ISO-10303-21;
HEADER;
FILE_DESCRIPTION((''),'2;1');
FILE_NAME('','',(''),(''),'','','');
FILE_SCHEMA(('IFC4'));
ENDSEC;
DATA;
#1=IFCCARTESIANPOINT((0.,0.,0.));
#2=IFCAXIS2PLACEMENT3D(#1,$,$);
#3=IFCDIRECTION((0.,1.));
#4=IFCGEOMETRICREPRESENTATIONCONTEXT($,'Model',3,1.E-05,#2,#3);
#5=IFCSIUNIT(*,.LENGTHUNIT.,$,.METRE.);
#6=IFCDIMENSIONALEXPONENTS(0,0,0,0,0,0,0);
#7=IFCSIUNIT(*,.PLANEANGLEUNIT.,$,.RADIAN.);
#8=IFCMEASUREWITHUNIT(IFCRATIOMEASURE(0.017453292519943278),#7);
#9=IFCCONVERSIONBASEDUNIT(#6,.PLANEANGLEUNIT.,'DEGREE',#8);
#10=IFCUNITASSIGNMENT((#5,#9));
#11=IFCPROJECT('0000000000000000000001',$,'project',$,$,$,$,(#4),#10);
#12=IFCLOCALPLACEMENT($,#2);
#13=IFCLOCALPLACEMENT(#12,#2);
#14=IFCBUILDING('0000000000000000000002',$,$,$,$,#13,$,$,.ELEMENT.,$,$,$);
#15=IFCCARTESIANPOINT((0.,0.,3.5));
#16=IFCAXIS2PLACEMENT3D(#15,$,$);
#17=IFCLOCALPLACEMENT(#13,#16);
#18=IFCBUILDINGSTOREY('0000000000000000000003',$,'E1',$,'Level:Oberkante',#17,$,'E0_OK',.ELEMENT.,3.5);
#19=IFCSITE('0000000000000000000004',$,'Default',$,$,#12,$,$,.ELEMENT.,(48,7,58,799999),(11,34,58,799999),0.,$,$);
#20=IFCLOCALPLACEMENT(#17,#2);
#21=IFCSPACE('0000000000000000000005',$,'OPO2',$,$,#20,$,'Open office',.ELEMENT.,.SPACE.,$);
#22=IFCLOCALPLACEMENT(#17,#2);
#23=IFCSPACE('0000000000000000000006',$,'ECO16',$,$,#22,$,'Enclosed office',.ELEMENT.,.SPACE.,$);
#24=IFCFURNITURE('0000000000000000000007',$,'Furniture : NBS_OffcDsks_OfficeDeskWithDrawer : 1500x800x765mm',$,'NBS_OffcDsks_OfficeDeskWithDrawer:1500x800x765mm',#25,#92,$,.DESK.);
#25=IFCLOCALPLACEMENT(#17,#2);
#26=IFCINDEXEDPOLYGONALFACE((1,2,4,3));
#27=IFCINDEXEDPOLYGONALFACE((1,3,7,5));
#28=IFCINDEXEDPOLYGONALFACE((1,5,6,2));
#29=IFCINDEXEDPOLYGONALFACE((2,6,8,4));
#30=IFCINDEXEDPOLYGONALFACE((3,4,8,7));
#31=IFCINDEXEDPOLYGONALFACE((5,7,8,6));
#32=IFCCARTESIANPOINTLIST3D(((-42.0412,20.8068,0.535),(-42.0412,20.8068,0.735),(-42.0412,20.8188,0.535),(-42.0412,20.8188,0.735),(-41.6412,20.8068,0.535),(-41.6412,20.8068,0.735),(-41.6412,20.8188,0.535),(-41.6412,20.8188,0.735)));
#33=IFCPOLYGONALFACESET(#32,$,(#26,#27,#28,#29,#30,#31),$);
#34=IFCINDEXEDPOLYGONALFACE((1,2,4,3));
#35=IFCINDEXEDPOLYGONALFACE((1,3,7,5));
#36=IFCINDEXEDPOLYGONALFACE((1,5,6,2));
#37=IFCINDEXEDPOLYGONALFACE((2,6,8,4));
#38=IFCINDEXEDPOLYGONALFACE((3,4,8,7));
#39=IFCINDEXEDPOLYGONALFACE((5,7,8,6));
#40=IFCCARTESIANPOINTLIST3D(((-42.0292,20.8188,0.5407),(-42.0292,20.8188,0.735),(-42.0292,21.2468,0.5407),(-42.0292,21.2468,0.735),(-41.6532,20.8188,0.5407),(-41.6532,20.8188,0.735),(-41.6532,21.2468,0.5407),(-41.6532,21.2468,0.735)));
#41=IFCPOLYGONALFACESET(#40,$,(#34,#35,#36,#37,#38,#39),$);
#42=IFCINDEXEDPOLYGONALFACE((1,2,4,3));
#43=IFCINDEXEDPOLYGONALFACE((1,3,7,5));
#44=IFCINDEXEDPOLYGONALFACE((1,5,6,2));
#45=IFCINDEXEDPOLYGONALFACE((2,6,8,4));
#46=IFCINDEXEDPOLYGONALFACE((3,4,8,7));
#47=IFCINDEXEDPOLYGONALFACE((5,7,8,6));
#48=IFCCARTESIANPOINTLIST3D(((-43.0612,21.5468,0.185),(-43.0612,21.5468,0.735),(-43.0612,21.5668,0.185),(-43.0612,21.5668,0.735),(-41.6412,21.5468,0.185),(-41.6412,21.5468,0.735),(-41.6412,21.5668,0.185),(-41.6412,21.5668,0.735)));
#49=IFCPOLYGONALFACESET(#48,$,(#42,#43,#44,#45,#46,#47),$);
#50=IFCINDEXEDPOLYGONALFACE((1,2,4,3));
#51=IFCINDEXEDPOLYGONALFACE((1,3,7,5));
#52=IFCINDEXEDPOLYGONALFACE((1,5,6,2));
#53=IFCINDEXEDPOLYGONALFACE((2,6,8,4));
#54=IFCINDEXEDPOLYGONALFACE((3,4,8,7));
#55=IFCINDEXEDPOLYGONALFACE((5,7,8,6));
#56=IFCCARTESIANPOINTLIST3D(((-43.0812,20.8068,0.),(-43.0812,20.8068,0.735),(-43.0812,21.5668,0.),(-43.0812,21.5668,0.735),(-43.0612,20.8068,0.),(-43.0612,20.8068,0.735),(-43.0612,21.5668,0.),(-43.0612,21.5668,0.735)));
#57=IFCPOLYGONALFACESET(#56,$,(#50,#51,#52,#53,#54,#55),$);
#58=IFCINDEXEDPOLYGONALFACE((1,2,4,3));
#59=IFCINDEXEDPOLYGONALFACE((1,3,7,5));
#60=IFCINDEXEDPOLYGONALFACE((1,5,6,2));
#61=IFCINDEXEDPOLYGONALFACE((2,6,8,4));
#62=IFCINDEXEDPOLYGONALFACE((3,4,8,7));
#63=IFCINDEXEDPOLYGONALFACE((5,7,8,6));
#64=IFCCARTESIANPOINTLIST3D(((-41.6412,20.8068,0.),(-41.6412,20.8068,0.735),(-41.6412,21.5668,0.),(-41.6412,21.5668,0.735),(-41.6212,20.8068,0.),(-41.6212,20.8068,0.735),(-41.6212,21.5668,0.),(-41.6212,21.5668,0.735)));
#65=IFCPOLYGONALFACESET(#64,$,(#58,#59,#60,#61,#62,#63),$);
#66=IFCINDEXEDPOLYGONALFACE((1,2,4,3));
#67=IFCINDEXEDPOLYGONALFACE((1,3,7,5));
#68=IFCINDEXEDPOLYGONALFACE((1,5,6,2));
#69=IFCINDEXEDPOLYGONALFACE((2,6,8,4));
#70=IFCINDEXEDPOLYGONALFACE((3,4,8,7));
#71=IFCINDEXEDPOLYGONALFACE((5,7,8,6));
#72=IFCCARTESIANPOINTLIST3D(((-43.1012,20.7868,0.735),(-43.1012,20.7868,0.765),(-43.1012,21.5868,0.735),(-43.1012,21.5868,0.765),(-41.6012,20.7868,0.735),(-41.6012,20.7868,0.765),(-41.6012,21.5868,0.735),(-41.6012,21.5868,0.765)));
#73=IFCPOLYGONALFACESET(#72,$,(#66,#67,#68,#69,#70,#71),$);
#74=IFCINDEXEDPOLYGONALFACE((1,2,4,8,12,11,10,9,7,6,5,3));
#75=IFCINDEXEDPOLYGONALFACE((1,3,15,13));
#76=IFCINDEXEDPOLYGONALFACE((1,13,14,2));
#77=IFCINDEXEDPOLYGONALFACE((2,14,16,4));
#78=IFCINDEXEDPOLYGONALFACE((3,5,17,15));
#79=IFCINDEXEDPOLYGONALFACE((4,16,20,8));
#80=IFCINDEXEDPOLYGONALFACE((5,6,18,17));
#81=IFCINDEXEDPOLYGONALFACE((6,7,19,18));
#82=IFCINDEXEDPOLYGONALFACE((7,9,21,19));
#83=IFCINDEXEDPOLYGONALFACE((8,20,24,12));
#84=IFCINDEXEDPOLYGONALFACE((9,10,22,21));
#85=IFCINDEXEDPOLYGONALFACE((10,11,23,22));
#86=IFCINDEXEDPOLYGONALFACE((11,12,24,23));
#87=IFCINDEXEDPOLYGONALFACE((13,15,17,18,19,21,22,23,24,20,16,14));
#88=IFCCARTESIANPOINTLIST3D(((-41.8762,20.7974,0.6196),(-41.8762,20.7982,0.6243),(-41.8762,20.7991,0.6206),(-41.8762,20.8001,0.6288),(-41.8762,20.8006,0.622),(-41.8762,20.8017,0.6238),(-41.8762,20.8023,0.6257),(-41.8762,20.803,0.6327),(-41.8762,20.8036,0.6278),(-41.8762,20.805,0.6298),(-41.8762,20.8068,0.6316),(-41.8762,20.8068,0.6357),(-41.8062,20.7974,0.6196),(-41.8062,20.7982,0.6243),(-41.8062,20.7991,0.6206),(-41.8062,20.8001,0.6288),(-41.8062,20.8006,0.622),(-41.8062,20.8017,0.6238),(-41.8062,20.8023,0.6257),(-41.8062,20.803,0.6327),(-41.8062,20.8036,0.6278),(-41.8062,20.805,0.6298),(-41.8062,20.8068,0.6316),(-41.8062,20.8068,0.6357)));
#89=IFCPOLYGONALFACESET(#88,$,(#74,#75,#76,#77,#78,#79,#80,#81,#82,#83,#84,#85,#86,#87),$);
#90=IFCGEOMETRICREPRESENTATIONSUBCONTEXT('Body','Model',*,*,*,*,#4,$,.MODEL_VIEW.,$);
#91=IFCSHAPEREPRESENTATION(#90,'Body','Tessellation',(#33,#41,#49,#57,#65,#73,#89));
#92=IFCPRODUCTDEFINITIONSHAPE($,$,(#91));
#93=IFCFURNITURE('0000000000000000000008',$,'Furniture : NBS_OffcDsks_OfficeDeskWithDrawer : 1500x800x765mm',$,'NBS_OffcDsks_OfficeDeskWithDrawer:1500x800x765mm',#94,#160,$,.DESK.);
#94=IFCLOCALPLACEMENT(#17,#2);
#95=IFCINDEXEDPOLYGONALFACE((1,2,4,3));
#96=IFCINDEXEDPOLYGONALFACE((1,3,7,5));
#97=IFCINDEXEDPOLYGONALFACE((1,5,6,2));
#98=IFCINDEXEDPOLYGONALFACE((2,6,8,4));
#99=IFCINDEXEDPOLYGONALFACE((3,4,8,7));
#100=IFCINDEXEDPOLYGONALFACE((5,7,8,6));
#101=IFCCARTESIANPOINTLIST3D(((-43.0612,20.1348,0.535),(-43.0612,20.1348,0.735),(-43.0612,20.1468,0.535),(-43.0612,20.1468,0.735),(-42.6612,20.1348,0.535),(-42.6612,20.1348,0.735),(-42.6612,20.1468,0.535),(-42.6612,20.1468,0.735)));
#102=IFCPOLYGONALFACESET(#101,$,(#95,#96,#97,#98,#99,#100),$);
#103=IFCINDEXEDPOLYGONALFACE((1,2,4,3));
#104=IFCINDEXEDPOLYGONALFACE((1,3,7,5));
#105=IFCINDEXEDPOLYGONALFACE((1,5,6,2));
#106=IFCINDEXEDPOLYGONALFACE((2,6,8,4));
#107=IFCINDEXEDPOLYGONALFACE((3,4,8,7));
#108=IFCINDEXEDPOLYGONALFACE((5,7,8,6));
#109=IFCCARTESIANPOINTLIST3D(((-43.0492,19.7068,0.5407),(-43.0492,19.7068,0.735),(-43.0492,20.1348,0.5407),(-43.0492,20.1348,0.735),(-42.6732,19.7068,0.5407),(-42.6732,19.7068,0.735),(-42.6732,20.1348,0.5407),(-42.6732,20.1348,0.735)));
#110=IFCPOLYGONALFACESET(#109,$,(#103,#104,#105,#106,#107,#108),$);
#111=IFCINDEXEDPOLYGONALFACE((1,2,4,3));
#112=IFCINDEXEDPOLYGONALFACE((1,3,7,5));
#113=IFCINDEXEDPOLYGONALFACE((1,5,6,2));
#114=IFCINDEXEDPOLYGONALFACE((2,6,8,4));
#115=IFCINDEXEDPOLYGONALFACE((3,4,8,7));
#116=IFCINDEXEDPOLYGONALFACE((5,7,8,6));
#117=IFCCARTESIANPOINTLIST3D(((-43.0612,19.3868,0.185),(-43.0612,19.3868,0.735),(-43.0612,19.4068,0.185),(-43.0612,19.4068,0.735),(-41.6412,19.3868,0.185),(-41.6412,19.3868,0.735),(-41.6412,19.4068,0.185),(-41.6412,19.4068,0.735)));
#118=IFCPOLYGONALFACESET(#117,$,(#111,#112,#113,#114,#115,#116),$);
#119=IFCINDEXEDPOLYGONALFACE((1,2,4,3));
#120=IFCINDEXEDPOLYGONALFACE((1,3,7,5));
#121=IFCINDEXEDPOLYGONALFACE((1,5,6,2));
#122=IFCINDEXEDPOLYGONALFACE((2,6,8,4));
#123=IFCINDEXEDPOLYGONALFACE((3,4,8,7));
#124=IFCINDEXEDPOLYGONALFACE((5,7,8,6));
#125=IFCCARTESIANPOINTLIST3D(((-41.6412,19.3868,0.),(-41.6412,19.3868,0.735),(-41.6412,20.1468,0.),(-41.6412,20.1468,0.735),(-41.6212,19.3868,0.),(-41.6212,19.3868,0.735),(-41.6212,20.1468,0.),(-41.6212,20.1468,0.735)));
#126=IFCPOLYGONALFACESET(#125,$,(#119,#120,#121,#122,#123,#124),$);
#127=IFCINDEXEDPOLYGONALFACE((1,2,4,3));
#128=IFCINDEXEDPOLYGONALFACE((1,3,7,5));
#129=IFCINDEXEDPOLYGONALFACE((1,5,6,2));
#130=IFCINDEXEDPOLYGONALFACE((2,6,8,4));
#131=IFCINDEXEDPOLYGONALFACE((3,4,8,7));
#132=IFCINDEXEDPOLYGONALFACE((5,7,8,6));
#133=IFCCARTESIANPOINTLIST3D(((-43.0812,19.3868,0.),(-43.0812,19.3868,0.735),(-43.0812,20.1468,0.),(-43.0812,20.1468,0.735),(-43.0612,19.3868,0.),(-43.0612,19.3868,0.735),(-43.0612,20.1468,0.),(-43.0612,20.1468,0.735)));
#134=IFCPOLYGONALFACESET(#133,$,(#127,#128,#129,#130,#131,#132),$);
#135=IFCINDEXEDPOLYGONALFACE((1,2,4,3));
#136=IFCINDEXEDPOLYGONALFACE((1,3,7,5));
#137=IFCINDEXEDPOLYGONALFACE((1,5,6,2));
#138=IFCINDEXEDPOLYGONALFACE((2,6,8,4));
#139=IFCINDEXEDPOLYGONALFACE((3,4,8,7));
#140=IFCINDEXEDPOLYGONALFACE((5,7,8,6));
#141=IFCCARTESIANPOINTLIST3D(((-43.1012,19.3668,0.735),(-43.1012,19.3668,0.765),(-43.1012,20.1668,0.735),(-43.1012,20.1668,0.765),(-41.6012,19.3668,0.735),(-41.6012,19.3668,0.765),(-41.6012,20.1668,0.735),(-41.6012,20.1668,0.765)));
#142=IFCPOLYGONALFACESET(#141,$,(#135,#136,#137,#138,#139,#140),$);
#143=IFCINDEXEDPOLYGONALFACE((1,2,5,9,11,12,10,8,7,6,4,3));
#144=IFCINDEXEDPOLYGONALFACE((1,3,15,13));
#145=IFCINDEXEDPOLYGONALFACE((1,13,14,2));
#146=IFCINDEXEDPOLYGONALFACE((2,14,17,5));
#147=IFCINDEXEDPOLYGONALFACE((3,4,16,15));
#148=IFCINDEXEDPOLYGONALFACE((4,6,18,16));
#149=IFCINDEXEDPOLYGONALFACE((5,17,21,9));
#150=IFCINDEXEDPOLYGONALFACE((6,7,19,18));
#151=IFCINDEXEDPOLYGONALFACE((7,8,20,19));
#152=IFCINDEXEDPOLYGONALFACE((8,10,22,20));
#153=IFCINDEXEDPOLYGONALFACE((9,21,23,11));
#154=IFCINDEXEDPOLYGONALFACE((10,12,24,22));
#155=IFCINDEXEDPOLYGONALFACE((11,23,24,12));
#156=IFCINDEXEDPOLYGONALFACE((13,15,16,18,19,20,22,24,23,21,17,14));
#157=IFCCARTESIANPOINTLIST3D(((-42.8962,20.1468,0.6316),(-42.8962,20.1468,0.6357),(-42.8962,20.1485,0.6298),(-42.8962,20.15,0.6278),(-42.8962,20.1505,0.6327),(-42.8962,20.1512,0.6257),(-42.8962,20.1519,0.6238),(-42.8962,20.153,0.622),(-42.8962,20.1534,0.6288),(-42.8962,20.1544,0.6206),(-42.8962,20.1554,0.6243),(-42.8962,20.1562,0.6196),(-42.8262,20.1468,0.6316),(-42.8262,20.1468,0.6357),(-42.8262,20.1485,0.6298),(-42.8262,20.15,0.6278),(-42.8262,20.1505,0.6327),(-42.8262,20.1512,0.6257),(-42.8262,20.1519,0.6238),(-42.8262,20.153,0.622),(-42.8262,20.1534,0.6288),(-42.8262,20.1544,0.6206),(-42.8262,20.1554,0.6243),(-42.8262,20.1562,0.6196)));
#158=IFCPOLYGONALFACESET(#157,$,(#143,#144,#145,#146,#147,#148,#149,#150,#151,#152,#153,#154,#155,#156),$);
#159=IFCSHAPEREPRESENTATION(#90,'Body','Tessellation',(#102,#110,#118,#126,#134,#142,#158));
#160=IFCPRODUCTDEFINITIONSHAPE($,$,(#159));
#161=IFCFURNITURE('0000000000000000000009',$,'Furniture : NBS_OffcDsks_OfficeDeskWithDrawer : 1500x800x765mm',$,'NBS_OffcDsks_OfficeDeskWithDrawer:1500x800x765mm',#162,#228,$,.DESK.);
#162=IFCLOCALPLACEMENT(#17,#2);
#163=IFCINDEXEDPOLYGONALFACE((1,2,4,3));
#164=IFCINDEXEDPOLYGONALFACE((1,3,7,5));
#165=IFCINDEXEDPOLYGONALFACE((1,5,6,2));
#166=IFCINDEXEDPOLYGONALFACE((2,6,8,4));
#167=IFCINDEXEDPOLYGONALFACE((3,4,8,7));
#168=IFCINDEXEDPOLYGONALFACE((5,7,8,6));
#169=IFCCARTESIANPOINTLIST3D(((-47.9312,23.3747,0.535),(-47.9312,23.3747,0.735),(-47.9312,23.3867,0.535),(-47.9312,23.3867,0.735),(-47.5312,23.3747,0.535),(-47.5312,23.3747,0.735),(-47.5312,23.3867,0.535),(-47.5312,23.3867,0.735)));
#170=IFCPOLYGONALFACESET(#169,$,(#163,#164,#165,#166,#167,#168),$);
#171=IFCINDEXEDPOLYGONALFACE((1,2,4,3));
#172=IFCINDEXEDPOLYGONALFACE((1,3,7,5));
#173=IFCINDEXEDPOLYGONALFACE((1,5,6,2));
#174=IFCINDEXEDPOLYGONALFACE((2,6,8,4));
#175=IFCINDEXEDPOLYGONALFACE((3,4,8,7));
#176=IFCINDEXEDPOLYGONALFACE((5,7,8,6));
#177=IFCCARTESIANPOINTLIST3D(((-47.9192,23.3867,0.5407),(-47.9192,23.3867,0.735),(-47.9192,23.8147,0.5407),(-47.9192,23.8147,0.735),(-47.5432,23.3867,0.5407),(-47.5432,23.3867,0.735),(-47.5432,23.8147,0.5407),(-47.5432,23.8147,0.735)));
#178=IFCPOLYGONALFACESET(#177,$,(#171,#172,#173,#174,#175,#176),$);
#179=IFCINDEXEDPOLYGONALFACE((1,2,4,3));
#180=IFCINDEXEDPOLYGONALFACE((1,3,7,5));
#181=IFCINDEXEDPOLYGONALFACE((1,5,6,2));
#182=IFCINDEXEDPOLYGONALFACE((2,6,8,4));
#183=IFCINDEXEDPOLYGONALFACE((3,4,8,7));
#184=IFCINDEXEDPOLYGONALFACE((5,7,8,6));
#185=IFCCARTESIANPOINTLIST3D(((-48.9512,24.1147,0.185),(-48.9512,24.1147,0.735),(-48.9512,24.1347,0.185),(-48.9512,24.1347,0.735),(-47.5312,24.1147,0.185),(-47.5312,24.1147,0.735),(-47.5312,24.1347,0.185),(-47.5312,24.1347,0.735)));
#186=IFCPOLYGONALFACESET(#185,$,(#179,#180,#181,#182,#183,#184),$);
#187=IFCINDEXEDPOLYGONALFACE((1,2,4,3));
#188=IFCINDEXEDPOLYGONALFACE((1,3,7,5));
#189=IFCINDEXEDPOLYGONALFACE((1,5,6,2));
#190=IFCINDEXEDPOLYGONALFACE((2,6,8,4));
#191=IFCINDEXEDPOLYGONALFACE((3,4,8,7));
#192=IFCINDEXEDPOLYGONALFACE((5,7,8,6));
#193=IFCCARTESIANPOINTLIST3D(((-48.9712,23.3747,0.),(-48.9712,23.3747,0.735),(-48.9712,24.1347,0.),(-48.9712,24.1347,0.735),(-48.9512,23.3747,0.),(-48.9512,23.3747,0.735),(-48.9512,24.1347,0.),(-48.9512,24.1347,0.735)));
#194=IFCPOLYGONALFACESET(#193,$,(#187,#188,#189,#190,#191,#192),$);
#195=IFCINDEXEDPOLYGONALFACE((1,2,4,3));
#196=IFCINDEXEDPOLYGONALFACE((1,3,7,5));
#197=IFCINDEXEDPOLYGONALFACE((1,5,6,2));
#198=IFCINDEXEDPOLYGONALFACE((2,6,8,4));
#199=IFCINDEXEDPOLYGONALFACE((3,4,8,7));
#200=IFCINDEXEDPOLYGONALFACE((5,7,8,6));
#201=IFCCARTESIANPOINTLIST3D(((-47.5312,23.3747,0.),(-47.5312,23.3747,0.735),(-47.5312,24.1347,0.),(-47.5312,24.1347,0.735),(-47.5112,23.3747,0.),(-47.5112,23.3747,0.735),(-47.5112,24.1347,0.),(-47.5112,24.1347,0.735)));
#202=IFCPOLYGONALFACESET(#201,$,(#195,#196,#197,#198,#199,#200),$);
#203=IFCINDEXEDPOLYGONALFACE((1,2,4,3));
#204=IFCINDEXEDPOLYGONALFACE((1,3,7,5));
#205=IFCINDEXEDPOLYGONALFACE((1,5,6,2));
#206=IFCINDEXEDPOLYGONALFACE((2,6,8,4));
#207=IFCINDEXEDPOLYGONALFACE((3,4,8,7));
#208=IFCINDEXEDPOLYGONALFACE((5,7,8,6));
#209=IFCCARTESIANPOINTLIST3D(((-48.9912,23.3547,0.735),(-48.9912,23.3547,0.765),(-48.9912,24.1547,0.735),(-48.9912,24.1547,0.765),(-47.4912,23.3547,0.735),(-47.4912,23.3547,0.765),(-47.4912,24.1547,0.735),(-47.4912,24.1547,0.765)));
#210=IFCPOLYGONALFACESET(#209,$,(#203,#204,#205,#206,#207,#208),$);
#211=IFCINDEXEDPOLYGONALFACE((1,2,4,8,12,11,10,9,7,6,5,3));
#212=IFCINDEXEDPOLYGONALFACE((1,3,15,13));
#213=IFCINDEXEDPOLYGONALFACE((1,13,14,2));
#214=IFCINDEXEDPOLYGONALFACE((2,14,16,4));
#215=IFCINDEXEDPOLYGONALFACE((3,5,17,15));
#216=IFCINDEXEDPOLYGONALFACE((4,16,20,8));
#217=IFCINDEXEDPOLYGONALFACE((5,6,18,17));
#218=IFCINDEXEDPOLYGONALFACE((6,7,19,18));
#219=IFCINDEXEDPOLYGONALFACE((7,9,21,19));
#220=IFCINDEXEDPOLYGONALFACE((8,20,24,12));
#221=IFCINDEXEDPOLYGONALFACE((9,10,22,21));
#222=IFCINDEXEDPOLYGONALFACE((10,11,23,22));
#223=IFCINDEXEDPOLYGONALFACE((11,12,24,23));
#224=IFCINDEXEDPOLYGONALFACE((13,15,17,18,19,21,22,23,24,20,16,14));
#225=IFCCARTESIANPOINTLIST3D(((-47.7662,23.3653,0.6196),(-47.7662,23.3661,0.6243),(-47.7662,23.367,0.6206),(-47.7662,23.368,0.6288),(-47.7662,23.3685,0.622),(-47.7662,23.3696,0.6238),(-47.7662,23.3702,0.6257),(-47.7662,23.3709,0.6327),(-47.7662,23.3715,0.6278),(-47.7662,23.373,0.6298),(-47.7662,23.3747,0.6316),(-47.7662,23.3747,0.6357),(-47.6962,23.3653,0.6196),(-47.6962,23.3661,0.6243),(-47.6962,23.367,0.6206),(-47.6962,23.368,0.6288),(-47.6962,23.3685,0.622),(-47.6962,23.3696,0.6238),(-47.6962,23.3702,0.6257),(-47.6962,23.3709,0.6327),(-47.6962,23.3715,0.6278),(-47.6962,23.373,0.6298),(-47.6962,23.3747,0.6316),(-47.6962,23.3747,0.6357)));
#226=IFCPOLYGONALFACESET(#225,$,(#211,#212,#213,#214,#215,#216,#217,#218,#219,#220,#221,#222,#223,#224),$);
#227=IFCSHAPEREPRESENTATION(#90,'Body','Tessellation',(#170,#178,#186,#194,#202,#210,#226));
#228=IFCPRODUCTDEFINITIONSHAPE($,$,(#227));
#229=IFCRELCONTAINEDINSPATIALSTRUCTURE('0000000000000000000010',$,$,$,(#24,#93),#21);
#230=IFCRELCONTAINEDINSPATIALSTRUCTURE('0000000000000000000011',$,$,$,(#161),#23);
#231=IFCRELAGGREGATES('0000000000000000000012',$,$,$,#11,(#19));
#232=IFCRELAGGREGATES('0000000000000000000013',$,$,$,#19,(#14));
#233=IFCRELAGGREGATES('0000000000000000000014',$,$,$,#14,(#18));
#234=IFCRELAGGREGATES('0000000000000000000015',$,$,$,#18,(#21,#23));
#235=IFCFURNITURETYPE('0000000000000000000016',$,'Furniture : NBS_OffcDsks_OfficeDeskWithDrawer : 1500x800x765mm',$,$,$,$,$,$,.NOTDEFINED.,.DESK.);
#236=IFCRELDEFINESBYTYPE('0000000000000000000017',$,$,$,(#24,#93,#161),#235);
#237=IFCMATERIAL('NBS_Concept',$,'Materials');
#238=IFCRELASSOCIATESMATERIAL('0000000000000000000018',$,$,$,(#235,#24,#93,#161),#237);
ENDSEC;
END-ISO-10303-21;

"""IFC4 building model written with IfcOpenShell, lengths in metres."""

from ifc_helpers import new_model, entity, si_unit, converted_unit, direction, frame, origin, place, context, subcontext, project, spatial, line, arc, indexed_curve, outline, extrude, source, transform, mapped, material, type_object, type_shapes, element, save


model = new_model("IFC4")

# Units and contexts
model_context = context("Model", 3, precision=1e-05, world=origin(), true_north=direction((0.0, 1.0)))
body_context = subcontext(model_context, "Body", "Model", "MODEL_VIEW")
ifc_project = project(units=[si_unit("LENGTHUNIT", "METRE"), converted_unit("PLANEANGLEUNIT", "DEGREE", entity("IfcRatioMeasure", 0.017453292519943278), si_unit("PLANEANGLEUNIT", "RADIAN"), dimensions=[0, 0, 0, 0, 0, 0, 0])], contexts=[model_context])

# Site, building, storey
site_placement = place(None, origin())
site = spatial("IfcSite", under=ifc_project, at=site_placement, Name="Default", CompositionType="ELEMENT", RefLatitude=(48, 7, 58, 799999), RefLongitude=(11, 34, 58, 799999), RefElevation=0.0)
building_placement = place(site_placement, origin())
building = spatial("IfcBuilding", under=site, at=building_placement, CompositionType="ELEMENT")
storey_placement = place(building_placement, frame((0.0, 0.0, 3.5)))
storey = spatial("IfcBuildingStorey", under=building, at=storey_placement, Name="E1", ObjectType="Level:Oberkante", LongName="E0_OK", CompositionType="ELEMENT", Elevation=3.5)

# Shared definitions
ifc_material_1 = material(Name="NBS_Concept", Category="Materials")
furniture_type = type_object("IfcFurnitureType", Name="Furniture : NBS_OffcDsks_OfficeDeskWithDrawer : 1500x800x765mm", AssemblyPlace="NOTDEFINED", PredefinedType="DESK", material=ifc_material_1)
shared_shape = source(origin(), body_context, "Body", "SweptSolid", [
    extrude(outline(indexed_curve([(-0.006, -0.2), (0.006, -0.2), (0.006, 0.2), (-0.006, 0.2), (-0.006, -0.2)], self_intersect=False)), frame((0.51, -0.374, 0.535), z_axis=(0.0, 0.0, 1.0), x_axis=(0.0, 1.0, 0.0)), (0.0, 0.0, 1.0), 0.2),
    extrude(outline(indexed_curve([(-0.188, -0.214), (0.188, -0.214), (0.188, 0.214), (-0.188, 0.214), (-0.188, -0.214)], self_intersect=False)), frame((0.51, -0.154, 0.5407), z_axis=(0.0, 0.0, 1.0), x_axis=(-1.0, 0.0, 0.0)), (0.0, 0.0, 1.0), 0.1943),
    extrude(outline(indexed_curve([(-0.71, -0.01), (0.71, -0.01), (0.71, 0.01), (-0.71, 0.01), (-0.71, -0.01)], self_intersect=False)), frame((0.0, 0.37, 0.185), z_axis=(0.0, 0.0, 1.0), x_axis=(-1.0, 0.0, 0.0)), (0.0, 0.0, 1.0), 0.55),
    extrude(outline(indexed_curve([(-0.01, -0.38), (0.01, -0.38), (0.01, 0.38), (-0.01, 0.38), (-0.01, -0.38)], self_intersect=False)), frame((-0.72, 0.0, 0.0), z_axis=(0.0, 0.0, 1.0), x_axis=(-1.0, 0.0, 0.0)), (0.0, 0.0, 1.0), 0.735),
    extrude(outline(indexed_curve([(-0.01, -0.38), (0.01, -0.38), (0.01, 0.38), (-0.01, 0.38), (-0.01, -0.38)], self_intersect=False)), frame((0.72, 0.0, 0.0), z_axis=(0.0, 0.0, 1.0), x_axis=(-1.0, 0.0, 0.0)), (0.0, 0.0, 1.0), 0.735),
    extrude(outline(indexed_curve([(-0.75, -0.4), (0.75, -0.4), (0.75, 0.4), (-0.75, 0.4), (-0.75, -0.4)], self_intersect=False)), frame((0.0, 0.0, 0.735), z_axis=(0.0, 0.0, 1.0), x_axis=(-1.0, 0.0, 0.0)), (0.0, 0.0, 1.0), 0.03),
    extrude(outline(indexed_curve([(0.0086, -0.0059), (0.0061, -0.0027), (0.0025, -0.001), (-0.0007, 0.0009), (-0.0034, 0.0035), (-0.0076, 0.0035), (-0.0007, -0.0032)], segments=[arc(1, 2, 3), arc(3, 4, 5), line(5, 6), arc(6, 7, 1)], self_intersect=False)), frame((0.475, -0.3835, 0.6281), z_axis=(1.0, 0.0, 0.0), x_axis=(0.0, 0.0, -1.0)), (0.0, 0.0, 1.0), 0.07),
])
type_shapes(furniture_type, [shared_shape])

# Shared definitions
space_1_placement = place(storey_placement, origin())
space_1 = spatial("IfcSpace", under=storey, at=space_1_placement, Name="OPO2", LongName="Open office", CompositionType="ELEMENT", PredefinedType="SPACE")

# Furniture
furniture_1_placement = place(space_1_placement, frame((-42.3512, 21.1868, 0.0)))
element("IfcFurniture", 1, at=furniture_1_placement, inside=space_1, type_object=furniture_type, material=ifc_material_1, Name="Furniture : NBS_OffcDsks_OfficeDeskWithDrawer : 1500x800x765mm", ObjectType="NBS_OffcDsks_OfficeDeskWithDrawer:1500x800x765mm", PredefinedType="DESK", context=body_context, shape_type="MappedRepresentation", body=[
    mapped(shared_shape, transform((0.0, 0.0, 0.0), scale=1.0)),
])
furniture_2_placement = place(space_1_placement, frame((-42.3512, 19.7668, 0.0), z_axis=(0.0, 0.0, 1.0), x_axis=(-1.0, 0.0, 0.0)))
element("IfcFurniture", 2, at=furniture_2_placement, inside=space_1, type_object=furniture_type, material=ifc_material_1, Name="Furniture : NBS_OffcDsks_OfficeDeskWithDrawer : 1500x800x765mm", ObjectType="NBS_OffcDsks_OfficeDeskWithDrawer:1500x800x765mm", PredefinedType="DESK", context=body_context, shape_type="MappedRepresentation", body=[
    mapped(shared_shape, transform((0.0, 0.0, 0.0), scale=1.0)),
])

# Shared definitions
space_2_placement = place(storey_placement, origin())
space_2 = spatial("IfcSpace", under=storey, at=space_2_placement, Name="ECO16", LongName="Enclosed office", CompositionType="ELEMENT", PredefinedType="SPACE")

# Furniture
furniture_3_placement = place(space_2_placement, frame((-48.2412, 23.7547, 0.0)))
element("IfcFurniture", 3, at=furniture_3_placement, inside=space_2, type_object=furniture_type, material=ifc_material_1, Name="Furniture : NBS_OffcDsks_OfficeDeskWithDrawer : 1500x800x765mm", ObjectType="NBS_OffcDsks_OfficeDeskWithDrawer:1500x800x765mm", PredefinedType="DESK", context=body_context, shape_type="MappedRepresentation", body=[
    mapped(shared_shape, transform((0.0, 0.0, 0.0), scale=1.0)),
])

save(model, "model.ifc")
